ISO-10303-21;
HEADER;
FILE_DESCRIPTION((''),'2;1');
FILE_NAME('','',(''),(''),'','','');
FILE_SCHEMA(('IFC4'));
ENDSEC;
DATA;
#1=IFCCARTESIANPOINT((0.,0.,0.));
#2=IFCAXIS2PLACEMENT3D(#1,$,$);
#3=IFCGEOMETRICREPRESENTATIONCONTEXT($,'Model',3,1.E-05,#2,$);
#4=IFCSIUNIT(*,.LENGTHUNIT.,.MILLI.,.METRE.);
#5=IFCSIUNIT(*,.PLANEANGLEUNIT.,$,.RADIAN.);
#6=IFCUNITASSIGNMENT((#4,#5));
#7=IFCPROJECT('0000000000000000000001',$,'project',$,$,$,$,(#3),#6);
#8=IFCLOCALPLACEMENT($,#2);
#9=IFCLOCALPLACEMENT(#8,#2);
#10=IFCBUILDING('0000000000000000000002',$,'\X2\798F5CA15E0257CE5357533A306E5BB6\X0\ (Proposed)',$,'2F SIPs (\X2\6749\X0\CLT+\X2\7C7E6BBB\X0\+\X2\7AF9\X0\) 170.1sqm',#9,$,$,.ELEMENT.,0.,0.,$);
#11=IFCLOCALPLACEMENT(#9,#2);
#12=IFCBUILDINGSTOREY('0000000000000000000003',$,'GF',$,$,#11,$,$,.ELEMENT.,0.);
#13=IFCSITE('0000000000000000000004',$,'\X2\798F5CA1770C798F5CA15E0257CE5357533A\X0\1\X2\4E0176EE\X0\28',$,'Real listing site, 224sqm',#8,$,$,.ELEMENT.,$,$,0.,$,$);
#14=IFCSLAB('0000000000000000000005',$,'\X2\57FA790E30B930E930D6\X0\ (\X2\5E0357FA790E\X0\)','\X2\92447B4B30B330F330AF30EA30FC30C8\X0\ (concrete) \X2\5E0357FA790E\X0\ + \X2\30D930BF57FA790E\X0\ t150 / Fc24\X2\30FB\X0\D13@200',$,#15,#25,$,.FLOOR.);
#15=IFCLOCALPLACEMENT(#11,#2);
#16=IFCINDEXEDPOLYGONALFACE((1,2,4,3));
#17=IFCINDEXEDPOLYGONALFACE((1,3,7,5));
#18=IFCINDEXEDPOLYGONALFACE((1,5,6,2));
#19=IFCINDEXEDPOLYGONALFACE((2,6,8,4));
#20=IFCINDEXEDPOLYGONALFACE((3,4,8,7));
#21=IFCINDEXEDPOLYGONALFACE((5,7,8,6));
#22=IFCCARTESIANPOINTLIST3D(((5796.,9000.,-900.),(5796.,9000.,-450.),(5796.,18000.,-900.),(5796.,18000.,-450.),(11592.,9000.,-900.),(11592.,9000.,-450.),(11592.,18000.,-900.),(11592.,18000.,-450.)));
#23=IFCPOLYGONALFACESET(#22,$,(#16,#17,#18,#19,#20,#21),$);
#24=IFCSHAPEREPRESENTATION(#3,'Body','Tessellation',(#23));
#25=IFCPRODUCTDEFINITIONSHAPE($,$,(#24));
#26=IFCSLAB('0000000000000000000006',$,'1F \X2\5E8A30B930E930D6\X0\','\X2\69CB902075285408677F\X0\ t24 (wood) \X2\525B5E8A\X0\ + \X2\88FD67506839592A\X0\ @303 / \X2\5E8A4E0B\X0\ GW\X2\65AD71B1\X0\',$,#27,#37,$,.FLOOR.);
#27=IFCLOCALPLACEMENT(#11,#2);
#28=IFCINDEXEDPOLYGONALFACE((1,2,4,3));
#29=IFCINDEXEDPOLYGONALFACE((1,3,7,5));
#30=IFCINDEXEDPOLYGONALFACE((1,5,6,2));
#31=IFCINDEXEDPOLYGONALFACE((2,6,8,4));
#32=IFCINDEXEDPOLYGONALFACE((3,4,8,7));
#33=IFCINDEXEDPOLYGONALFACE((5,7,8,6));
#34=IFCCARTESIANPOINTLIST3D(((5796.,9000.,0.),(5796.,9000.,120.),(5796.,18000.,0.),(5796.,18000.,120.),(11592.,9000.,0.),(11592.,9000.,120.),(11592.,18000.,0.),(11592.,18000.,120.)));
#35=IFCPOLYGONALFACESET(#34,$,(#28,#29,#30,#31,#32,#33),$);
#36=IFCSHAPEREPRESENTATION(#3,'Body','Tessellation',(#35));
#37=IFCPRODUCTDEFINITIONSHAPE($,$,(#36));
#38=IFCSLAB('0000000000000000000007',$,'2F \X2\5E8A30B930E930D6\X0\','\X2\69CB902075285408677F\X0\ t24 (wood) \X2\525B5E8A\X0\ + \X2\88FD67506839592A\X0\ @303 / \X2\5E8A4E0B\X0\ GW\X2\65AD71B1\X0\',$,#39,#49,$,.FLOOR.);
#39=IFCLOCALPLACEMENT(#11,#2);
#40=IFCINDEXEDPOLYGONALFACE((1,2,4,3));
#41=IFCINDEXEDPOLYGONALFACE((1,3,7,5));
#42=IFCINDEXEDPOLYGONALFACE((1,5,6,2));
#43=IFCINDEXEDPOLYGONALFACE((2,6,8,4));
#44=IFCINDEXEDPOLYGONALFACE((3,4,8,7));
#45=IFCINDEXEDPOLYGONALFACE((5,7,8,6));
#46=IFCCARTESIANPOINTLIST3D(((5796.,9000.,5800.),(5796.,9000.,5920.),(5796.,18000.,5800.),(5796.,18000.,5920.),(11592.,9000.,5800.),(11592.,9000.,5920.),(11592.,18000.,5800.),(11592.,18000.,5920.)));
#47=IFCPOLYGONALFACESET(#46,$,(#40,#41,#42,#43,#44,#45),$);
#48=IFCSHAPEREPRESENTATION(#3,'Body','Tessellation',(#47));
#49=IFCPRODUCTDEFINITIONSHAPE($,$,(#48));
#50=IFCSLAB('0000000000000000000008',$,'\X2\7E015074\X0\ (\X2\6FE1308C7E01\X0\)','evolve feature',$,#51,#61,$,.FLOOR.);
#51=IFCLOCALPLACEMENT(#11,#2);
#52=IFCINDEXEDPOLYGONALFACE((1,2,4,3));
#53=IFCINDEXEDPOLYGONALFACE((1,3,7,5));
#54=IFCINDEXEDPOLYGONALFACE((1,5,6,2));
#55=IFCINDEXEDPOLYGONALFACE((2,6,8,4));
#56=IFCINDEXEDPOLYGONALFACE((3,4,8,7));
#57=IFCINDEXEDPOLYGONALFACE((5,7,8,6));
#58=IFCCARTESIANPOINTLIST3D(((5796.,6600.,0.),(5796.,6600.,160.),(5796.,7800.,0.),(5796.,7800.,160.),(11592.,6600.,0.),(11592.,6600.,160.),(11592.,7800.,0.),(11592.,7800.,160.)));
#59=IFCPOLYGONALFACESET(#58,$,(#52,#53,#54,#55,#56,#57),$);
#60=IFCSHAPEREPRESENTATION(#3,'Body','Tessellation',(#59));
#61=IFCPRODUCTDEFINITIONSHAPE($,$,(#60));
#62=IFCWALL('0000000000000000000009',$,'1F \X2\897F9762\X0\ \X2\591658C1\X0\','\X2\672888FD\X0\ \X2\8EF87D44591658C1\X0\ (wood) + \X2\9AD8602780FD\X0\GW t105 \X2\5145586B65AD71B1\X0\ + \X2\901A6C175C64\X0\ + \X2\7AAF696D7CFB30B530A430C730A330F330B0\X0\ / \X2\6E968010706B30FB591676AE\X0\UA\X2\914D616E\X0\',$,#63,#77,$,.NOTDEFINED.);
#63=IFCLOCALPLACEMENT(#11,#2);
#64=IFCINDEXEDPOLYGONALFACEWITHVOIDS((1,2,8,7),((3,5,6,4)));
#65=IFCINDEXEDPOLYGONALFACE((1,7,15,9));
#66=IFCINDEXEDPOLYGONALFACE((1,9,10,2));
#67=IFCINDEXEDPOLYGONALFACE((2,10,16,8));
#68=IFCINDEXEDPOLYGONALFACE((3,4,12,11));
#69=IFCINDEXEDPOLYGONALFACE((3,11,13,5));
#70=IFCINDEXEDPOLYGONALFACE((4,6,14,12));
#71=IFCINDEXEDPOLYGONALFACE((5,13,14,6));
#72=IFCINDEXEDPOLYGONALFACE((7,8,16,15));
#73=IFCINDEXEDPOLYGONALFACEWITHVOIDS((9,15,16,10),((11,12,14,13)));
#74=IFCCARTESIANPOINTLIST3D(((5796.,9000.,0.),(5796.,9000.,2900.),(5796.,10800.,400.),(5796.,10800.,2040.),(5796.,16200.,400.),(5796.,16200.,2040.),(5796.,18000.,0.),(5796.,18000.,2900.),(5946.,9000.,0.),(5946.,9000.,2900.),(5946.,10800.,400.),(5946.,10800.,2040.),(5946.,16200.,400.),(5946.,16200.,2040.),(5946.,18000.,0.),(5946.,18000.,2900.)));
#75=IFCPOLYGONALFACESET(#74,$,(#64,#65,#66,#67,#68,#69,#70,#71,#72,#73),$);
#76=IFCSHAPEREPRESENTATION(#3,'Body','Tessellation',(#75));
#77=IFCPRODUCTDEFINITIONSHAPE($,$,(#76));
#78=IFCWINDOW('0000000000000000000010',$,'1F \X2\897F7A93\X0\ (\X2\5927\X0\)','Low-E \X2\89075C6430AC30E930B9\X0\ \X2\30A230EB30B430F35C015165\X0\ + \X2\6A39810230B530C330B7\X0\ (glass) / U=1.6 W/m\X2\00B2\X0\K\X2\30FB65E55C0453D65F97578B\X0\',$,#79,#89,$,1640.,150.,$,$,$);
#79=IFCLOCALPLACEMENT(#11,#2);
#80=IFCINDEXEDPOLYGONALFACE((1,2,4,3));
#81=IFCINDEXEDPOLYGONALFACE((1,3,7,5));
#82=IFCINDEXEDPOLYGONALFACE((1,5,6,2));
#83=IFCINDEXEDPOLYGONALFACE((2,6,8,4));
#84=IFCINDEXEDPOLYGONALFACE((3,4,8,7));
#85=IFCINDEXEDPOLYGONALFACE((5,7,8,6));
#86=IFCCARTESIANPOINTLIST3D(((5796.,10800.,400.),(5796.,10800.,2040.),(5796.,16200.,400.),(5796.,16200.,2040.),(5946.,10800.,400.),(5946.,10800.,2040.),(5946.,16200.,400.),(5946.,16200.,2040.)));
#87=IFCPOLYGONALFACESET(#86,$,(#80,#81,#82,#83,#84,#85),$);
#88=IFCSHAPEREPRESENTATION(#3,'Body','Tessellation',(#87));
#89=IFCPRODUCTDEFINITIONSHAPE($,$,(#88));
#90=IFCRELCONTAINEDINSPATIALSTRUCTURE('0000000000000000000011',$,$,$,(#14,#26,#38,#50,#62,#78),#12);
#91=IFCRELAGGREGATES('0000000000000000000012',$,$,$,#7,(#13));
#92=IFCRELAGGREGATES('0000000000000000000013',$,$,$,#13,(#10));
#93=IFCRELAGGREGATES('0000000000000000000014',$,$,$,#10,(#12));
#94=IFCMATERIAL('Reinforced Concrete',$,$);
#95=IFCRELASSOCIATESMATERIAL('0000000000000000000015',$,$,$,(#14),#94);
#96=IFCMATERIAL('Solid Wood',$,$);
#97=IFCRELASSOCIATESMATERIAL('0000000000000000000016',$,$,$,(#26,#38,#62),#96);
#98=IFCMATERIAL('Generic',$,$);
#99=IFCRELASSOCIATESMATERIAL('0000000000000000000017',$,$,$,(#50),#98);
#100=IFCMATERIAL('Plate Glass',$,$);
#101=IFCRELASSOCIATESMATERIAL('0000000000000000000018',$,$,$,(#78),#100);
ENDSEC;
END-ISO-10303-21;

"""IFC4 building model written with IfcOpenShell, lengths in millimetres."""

from ifc_helpers import new_model, si_unit, frame, frame_2d, origin, place, context, project, spatial, rectangle, extrude, material, element, fill, save


model = new_model("IFC4")

# Units and contexts
model_context = context("Model", 3, precision=1e-05, world=origin())
ifc_project = project(units=[si_unit("LENGTHUNIT", "METRE", prefix="MILLI"), si_unit("PLANEANGLEUNIT", "RADIAN")], contexts=[model_context])

# Site, building, storey
site_placement = place(None, origin())
site = spatial("IfcSite", under=ifc_project, at=site_placement, Name="福岡県福岡市城南区1丁目28", ObjectType="Real listing site, 224sqm", CompositionType="ELEMENT", RefElevation=0.0)
building_placement = place(site_placement, origin())
building = spatial("IfcBuilding", under=site, at=building_placement, Name="福岡市城南区の家 (Proposed)", ObjectType="2F SIPs (杉CLT+籾殻+竹) 170.1sqm", CompositionType="ELEMENT", ElevationOfRefHeight=0.0, ElevationOfTerrain=0.0)
storey_placement = place(building_placement, origin())
storey = spatial("IfcBuildingStorey", under=building, at=storey_placement, Name="GF", CompositionType="ELEMENT", Elevation=0.0)

# Slabs
ifc_material_1 = material(Name="Reinforced Concrete")
slab_1_placement = place(storey_placement, frame((2898.0, 4500.0, -450.0)))
element("IfcSlab", 1, at=slab_1_placement, inside=storey, material=ifc_material_1, Name="基礎スラブ (布基礎)", Description="鉄筋コンクリート (concrete) 布基礎 + ベタ基礎 t150 / Fc24・D13@200", PredefinedType="FLOOR", context=model_context, shape_type="SweptSolid", body=[
    extrude(rectangle(XDim=5796.0, YDim=9000.0, at=frame_2d((2898.0, 4500.0))), frame((2898.0, 4500.0, -450.0)), (0.0, 0.0, 1.0), 450.0),
])
ifc_material_2 = material(Name="Solid Wood")
slab_2_placement = place(storey_placement, frame((2898.0, 4500.0, 0.0)))
element("IfcSlab", 2, at=slab_2_placement, inside=storey, material=ifc_material_2, Name="1F 床スラブ", Description="構造用合板 t24 (wood) 剛床 + 製材根太 @303 / 床下 GW断熱", PredefinedType="FLOOR", context=model_context, shape_type="SweptSolid", body=[
    extrude(rectangle(XDim=5796.0, YDim=9000.0, at=frame_2d((2898.0, 4500.0))), frame((2898.0, 4500.0, 0.0)), (0.0, 0.0, 1.0), 120.0),
])
slab_3_placement = place(storey_placement, frame((2898.0, 4500.0, 2900.0)))
element("IfcSlab", 3, at=slab_3_placement, inside=storey, material=ifc_material_2, Name="2F 床スラブ", Description="構造用合板 t24 (wood) 剛床 + 製材根太 @303 / 床下 GW断熱", PredefinedType="FLOOR", context=model_context, shape_type="SweptSolid", body=[
    extrude(rectangle(XDim=5796.0, YDim=9000.0, at=frame_2d((2898.0, 4500.0))), frame((2898.0, 4500.0, 2900.0)), (0.0, 0.0, 1.0), 120.0),
])
ifc_material_3 = material(Name="Generic")
slab_4_placement = place(storey_placement, frame((2898.0, 3300.0, 0.0)))
element("IfcSlab", 4, at=slab_4_placement, inside=storey, material=ifc_material_3, Name="縁側 (濡れ縁)", Description="evolve feature", PredefinedType="FLOOR", context=model_context, shape_type="SweptSolid", body=[
    extrude(rectangle(XDim=5796.0, YDim=1200.0, at=frame_2d((2898.0, 600.0))), frame((2898.0, 3300.0, 0.0)), (0.0, 0.0, 1.0), 160.0),
])

# Shared definitions
ifc_material_4 = material(Name="Plate Glass")

# Wall, opening, window
wall_1_placement = place(storey_placement, frame((2898.0, 4500.0, 0.0)))
wall_1 = element("IfcWall", 5, at=wall_1_placement, inside=storey, material=ifc_material_2, Name="1F 西面 外壁", Description="木製 軸組外壁 (wood) + 高性能GW t105 充填断熱 + 通気層 + 窯業系サイディング / 準耐火・外皮UA配慮", PredefinedType="NOTDEFINED", context=model_context, shape_type="SweptSolid", body=[
    extrude(rectangle(XDim=150.0, YDim=9000.0, at=frame_2d((75.0, 4500.0))), frame((2898.0, 4500.0, 0.0)), (0.0, 0.0, 1.0), 2900.0),
])
opening_1_placement = place(storey_placement, frame((2898.0, 5400.0, 200.0)))
opening_1 = element("IfcOpeningElement", 6, at=opening_1_placement, cuts=wall_1, PredefinedType="NOTDEFINED", context=model_context, shape_type="SweptSolid", body=[
    extrude(rectangle(XDim=150.0, YDim=5400.0, at=frame_2d((75.0, 2700.0))), frame((2898.0, 5400.0, 200.0)), (0.0, 0.0, 1.0), 1640.0),
])
window_1_placement = place(storey_placement, frame((2898.0, 5400.0, 200.0)))
window_1 = element("IfcWindow", 7, at=window_1_placement, inside=storey, material=ifc_material_4, Name="1F 西窓 (大)", Description="Low-E 複層ガラス アルゴン封入 + 樹脂サッシ (glass) / U=1.6 W/m²K・日射取得型", OverallHeight=1640.0, OverallWidth=150.0, context=model_context, shape_type="SweptSolid", body=[
    extrude(rectangle(XDim=150.0, YDim=5400.0, at=frame_2d((75.0, 2700.0))), frame((2898.0, 5400.0, 200.0)), (0.0, 0.0, 1.0), 1640.0),
])
fill(opening_1, window_1)

save(model, "model.ifc")
